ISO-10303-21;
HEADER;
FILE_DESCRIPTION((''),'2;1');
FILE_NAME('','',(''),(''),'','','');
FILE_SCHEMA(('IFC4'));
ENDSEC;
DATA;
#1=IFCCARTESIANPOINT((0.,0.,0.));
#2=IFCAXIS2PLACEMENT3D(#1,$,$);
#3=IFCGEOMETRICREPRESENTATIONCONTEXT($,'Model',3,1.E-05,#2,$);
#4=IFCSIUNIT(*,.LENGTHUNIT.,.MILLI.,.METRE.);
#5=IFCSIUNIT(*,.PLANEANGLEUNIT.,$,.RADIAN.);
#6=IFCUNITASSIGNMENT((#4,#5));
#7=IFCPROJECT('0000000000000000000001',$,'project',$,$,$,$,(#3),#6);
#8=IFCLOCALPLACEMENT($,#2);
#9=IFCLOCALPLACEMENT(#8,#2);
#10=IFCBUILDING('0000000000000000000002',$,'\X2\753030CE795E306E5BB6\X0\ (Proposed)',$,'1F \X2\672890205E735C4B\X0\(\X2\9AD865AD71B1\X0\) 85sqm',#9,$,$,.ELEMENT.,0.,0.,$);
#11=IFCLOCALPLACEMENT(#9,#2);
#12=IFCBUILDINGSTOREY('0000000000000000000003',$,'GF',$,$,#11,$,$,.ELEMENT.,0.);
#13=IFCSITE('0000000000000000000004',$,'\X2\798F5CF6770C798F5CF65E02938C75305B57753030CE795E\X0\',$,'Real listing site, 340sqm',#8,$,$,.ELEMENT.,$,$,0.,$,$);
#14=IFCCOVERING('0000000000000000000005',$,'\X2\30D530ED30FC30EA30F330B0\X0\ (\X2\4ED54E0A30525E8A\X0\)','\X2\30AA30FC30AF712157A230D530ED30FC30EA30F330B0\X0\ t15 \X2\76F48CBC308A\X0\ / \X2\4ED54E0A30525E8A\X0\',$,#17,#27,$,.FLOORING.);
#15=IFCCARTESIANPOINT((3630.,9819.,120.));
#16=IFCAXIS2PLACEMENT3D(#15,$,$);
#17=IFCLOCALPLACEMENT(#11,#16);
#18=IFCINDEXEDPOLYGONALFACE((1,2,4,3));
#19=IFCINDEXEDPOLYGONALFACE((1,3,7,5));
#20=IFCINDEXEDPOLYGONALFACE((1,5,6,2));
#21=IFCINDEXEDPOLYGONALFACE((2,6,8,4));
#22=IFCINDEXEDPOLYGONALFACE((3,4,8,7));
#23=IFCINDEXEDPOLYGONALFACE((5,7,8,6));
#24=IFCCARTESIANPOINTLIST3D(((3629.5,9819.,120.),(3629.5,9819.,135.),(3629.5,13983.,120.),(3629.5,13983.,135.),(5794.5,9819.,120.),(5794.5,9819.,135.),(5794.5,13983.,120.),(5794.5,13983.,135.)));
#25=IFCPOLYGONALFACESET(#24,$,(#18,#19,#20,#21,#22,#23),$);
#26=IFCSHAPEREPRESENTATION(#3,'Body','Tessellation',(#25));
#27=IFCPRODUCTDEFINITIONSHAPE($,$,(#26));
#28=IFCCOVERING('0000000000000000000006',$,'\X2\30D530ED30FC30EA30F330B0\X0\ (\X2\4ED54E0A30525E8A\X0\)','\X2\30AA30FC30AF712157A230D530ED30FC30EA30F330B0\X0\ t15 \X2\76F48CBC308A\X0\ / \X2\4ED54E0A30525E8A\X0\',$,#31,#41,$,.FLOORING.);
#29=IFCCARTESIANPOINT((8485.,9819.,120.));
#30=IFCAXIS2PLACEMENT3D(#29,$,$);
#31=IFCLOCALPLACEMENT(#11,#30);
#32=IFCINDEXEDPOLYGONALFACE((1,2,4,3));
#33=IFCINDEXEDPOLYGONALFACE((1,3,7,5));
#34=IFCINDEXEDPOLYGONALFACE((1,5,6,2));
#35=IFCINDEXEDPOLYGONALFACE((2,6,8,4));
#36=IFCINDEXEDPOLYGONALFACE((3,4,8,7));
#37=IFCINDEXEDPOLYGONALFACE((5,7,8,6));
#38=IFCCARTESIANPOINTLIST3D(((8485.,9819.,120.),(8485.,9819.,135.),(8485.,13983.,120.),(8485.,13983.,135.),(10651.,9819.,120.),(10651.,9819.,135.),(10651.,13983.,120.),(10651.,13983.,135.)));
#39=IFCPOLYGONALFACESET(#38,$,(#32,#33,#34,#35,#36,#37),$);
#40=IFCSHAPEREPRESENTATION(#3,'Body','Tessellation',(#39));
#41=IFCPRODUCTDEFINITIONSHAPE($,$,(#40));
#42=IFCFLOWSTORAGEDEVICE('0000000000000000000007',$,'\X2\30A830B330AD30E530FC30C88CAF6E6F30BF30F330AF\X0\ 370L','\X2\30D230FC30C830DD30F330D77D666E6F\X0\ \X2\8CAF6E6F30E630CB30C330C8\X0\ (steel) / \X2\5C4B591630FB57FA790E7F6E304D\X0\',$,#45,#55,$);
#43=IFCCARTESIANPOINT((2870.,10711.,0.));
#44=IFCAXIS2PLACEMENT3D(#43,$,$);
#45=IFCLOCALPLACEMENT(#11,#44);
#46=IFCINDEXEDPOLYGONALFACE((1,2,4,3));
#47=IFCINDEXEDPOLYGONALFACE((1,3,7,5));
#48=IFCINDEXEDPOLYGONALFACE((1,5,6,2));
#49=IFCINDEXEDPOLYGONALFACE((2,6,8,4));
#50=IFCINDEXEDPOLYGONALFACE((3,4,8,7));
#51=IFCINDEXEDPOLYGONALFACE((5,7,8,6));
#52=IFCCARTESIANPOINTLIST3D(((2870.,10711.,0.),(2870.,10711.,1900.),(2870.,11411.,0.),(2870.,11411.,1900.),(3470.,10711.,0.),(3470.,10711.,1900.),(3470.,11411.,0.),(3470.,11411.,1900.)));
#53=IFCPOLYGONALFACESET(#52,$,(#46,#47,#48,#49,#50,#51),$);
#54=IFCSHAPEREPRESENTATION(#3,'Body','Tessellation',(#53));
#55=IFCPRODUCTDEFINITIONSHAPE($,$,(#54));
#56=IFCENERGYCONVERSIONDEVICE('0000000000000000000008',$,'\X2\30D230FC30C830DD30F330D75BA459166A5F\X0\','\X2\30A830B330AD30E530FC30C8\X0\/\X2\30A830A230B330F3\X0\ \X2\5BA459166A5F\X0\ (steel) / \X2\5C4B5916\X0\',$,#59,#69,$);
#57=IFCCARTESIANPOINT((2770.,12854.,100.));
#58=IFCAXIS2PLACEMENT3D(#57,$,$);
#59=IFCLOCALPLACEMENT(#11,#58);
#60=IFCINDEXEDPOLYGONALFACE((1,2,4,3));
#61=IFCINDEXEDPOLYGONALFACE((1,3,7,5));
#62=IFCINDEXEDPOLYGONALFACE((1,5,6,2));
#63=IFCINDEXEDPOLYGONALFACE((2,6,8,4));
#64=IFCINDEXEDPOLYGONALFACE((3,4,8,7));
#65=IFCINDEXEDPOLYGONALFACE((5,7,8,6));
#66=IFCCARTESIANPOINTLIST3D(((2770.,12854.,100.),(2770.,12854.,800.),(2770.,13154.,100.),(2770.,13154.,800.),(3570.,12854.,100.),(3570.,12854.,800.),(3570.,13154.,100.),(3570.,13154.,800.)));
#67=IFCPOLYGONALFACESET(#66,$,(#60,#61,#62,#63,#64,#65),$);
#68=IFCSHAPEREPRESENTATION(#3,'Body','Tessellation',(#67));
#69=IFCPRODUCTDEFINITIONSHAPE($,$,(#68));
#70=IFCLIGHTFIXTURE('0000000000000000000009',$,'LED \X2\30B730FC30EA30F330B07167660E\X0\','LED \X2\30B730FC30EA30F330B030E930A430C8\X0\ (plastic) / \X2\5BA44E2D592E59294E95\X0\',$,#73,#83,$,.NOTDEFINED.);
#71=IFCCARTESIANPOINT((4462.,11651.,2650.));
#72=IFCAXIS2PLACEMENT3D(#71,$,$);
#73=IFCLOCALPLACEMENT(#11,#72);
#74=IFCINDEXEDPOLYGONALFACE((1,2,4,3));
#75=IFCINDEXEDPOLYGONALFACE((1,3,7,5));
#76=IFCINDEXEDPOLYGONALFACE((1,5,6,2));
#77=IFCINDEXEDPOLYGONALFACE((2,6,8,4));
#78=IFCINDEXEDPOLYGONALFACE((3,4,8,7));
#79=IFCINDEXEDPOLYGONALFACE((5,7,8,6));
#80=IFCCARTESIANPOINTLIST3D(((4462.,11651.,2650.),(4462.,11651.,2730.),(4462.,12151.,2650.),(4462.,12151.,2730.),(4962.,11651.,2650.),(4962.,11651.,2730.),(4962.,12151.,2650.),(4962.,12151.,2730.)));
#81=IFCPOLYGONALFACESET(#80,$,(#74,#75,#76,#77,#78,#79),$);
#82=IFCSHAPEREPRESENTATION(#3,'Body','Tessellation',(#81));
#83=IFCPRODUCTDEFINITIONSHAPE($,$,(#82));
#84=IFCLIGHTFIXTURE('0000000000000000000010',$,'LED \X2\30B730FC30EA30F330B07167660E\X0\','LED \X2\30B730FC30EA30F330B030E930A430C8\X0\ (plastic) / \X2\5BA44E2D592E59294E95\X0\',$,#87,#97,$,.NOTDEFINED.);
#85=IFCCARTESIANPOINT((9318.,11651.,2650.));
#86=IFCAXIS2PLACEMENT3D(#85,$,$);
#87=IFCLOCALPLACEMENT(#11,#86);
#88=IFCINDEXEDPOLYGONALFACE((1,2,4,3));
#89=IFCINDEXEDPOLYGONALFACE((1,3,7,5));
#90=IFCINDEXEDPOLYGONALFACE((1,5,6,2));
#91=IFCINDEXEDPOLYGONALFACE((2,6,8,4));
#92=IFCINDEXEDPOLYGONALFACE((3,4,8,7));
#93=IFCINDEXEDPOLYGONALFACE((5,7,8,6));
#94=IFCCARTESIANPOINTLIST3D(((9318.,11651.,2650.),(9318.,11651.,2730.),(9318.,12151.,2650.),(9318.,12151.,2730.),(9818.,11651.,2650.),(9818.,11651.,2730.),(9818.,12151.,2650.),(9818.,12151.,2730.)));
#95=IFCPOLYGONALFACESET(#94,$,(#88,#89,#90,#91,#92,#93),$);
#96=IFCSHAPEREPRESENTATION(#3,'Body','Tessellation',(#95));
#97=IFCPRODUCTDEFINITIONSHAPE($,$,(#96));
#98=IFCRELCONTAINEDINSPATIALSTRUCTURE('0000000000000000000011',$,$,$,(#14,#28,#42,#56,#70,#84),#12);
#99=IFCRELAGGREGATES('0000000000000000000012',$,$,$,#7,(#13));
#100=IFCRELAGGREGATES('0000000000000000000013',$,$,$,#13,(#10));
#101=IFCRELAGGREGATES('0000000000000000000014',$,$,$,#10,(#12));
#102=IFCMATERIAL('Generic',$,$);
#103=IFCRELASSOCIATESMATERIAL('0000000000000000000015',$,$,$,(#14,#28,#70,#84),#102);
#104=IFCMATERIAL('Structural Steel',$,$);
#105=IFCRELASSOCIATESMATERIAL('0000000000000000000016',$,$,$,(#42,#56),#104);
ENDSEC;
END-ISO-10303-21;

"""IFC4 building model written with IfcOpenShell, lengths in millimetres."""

from ifc_helpers import new_model, si_unit, frame, frame_2d, origin, place, context, project, spatial, rectangle, extrude, material, element, save


model = new_model("IFC4")

# Units and contexts
model_context = context("Model", 3, precision=1e-05, world=origin())
ifc_project = project(units=[si_unit("LENGTHUNIT", "METRE", prefix="MILLI"), si_unit("PLANEANGLEUNIT", "RADIAN")], contexts=[model_context])

# Site, building, storey
site_placement = place(None, origin())
site = spatial("IfcSite", under=ifc_project, at=site_placement, Name="福島県福島市鎌田字田ノ神", ObjectType="Real listing site, 340sqm", CompositionType="ELEMENT", RefElevation=0.0)
building_placement = place(site_placement, origin())
building = spatial("IfcBuilding", under=site, at=building_placement, Name="田ノ神の家 (Proposed)", ObjectType="1F 木造平屋(高断熱) 85sqm", CompositionType="ELEMENT", ElevationOfRefHeight=0.0, ElevationOfTerrain=0.0)
storey_placement = place(building_placement, origin())
storey = spatial("IfcBuildingStorey", under=building, at=storey_placement, Name="GF", CompositionType="ELEMENT", Elevation=0.0)

# Shared definitions
ifc_material_1 = material(Name="Structural Steel")

# Coverings
ifc_material_2 = material(Name="Generic")
covering_1_placement = place(storey_placement, frame((3630.0, 9819.0, 120.0)))
element("IfcCovering", 1, at=covering_1_placement, inside=storey, material=ifc_material_2, Name="フローリング (仕上げ床)", Description="オーク無垢フローリング t15 直貼り / 仕上げ床", PredefinedType="FLOORING", context=model_context, shape_type="SweptSolid", body=[
    extrude(rectangle(XDim=2165.0, YDim=4164.0, at=frame_2d((1082.0, 2082.0))), frame((3630.0, 9819.0, 120.0)), (0.0, 0.0, 1.0), 15.0),
])
covering_2_placement = place(storey_placement, frame((8485.0, 9819.0, 120.0)))
element("IfcCovering", 2, at=covering_2_placement, inside=storey, material=ifc_material_2, Name="フローリング (仕上げ床)", Description="オーク無垢フローリング t15 直貼り / 仕上げ床", PredefinedType="FLOORING", context=model_context, shape_type="SweptSolid", body=[
    extrude(rectangle(XDim=2166.0, YDim=4164.0, at=frame_2d((1083.0, 2082.0))), frame((8485.0, 9819.0, 120.0)), (0.0, 0.0, 1.0), 15.0),
])

# Flow storage device
flow_storage_device_placement = place(storey_placement, frame((2870.0, 10711.0, 0.0)))
element("IfcFlowStorageDevice", 3, at=flow_storage_device_placement, inside=storey, material=ifc_material_1, Name="エコキュート貯湯タンク 370L", Description="ヒートポンプ給湯 貯湯ユニット (steel) / 屋外・基礎置き", context=model_context, shape_type="SweptSolid", body=[
    extrude(rectangle(XDim=600.0, YDim=700.0, at=frame_2d((300.0, 350.0))), frame((2870.0, 10711.0, 0.0)), (0.0, 0.0, 1.0), 1900.0),
])

# Energy conversion device
energy_conversion_device_placement = place(storey_placement, frame((2770.0, 12854.0, 100.0)))
element("IfcEnergyConversionDevice", 4, at=energy_conversion_device_placement, inside=storey, material=ifc_material_1, Name="ヒートポンプ室外機", Description="エコキュート/エアコン 室外機 (steel) / 屋外", context=model_context, shape_type="SweptSolid", body=[
    extrude(rectangle(XDim=800.0, YDim=300.0, at=frame_2d((400.0, 150.0))), frame((2770.0, 12854.0, 100.0)), (0.0, 0.0, 1.0), 700.0),
])

# Light fixtures
light_fixture_1_placement = place(storey_placement, frame((4462.0, 11651.0, 2650.0)))
element("IfcLightFixture", 5, at=light_fixture_1_placement, inside=storey, material=ifc_material_2, Name="LED シーリング照明", Description="LED シーリングライト (plastic) / 室中央天井", PredefinedType="NOTDEFINED", context=model_context, shape_type="SweptSolid", body=[
    extrude(rectangle(XDim=500.0, YDim=500.0, at=frame_2d((250.0, 250.0))), frame((4462.0, 11651.0, 2650.0)), (0.0, 0.0, 1.0), 80.0),
])
light_fixture_2_placement = place(storey_placement, frame((9318.0, 11651.0, 2650.0)))
element("IfcLightFixture", 6, at=light_fixture_2_placement, inside=storey, material=ifc_material_2, Name="LED シーリング照明", Description="LED シーリングライト (plastic) / 室中央天井", PredefinedType="NOTDEFINED", context=model_context, shape_type="SweptSolid", body=[
    extrude(rectangle(XDim=500.0, YDim=500.0, at=frame_2d((250.0, 250.0))), frame((9318.0, 11651.0, 2650.0)), (0.0, 0.0, 1.0), 80.0),
])

save(model, "model.ifc")
